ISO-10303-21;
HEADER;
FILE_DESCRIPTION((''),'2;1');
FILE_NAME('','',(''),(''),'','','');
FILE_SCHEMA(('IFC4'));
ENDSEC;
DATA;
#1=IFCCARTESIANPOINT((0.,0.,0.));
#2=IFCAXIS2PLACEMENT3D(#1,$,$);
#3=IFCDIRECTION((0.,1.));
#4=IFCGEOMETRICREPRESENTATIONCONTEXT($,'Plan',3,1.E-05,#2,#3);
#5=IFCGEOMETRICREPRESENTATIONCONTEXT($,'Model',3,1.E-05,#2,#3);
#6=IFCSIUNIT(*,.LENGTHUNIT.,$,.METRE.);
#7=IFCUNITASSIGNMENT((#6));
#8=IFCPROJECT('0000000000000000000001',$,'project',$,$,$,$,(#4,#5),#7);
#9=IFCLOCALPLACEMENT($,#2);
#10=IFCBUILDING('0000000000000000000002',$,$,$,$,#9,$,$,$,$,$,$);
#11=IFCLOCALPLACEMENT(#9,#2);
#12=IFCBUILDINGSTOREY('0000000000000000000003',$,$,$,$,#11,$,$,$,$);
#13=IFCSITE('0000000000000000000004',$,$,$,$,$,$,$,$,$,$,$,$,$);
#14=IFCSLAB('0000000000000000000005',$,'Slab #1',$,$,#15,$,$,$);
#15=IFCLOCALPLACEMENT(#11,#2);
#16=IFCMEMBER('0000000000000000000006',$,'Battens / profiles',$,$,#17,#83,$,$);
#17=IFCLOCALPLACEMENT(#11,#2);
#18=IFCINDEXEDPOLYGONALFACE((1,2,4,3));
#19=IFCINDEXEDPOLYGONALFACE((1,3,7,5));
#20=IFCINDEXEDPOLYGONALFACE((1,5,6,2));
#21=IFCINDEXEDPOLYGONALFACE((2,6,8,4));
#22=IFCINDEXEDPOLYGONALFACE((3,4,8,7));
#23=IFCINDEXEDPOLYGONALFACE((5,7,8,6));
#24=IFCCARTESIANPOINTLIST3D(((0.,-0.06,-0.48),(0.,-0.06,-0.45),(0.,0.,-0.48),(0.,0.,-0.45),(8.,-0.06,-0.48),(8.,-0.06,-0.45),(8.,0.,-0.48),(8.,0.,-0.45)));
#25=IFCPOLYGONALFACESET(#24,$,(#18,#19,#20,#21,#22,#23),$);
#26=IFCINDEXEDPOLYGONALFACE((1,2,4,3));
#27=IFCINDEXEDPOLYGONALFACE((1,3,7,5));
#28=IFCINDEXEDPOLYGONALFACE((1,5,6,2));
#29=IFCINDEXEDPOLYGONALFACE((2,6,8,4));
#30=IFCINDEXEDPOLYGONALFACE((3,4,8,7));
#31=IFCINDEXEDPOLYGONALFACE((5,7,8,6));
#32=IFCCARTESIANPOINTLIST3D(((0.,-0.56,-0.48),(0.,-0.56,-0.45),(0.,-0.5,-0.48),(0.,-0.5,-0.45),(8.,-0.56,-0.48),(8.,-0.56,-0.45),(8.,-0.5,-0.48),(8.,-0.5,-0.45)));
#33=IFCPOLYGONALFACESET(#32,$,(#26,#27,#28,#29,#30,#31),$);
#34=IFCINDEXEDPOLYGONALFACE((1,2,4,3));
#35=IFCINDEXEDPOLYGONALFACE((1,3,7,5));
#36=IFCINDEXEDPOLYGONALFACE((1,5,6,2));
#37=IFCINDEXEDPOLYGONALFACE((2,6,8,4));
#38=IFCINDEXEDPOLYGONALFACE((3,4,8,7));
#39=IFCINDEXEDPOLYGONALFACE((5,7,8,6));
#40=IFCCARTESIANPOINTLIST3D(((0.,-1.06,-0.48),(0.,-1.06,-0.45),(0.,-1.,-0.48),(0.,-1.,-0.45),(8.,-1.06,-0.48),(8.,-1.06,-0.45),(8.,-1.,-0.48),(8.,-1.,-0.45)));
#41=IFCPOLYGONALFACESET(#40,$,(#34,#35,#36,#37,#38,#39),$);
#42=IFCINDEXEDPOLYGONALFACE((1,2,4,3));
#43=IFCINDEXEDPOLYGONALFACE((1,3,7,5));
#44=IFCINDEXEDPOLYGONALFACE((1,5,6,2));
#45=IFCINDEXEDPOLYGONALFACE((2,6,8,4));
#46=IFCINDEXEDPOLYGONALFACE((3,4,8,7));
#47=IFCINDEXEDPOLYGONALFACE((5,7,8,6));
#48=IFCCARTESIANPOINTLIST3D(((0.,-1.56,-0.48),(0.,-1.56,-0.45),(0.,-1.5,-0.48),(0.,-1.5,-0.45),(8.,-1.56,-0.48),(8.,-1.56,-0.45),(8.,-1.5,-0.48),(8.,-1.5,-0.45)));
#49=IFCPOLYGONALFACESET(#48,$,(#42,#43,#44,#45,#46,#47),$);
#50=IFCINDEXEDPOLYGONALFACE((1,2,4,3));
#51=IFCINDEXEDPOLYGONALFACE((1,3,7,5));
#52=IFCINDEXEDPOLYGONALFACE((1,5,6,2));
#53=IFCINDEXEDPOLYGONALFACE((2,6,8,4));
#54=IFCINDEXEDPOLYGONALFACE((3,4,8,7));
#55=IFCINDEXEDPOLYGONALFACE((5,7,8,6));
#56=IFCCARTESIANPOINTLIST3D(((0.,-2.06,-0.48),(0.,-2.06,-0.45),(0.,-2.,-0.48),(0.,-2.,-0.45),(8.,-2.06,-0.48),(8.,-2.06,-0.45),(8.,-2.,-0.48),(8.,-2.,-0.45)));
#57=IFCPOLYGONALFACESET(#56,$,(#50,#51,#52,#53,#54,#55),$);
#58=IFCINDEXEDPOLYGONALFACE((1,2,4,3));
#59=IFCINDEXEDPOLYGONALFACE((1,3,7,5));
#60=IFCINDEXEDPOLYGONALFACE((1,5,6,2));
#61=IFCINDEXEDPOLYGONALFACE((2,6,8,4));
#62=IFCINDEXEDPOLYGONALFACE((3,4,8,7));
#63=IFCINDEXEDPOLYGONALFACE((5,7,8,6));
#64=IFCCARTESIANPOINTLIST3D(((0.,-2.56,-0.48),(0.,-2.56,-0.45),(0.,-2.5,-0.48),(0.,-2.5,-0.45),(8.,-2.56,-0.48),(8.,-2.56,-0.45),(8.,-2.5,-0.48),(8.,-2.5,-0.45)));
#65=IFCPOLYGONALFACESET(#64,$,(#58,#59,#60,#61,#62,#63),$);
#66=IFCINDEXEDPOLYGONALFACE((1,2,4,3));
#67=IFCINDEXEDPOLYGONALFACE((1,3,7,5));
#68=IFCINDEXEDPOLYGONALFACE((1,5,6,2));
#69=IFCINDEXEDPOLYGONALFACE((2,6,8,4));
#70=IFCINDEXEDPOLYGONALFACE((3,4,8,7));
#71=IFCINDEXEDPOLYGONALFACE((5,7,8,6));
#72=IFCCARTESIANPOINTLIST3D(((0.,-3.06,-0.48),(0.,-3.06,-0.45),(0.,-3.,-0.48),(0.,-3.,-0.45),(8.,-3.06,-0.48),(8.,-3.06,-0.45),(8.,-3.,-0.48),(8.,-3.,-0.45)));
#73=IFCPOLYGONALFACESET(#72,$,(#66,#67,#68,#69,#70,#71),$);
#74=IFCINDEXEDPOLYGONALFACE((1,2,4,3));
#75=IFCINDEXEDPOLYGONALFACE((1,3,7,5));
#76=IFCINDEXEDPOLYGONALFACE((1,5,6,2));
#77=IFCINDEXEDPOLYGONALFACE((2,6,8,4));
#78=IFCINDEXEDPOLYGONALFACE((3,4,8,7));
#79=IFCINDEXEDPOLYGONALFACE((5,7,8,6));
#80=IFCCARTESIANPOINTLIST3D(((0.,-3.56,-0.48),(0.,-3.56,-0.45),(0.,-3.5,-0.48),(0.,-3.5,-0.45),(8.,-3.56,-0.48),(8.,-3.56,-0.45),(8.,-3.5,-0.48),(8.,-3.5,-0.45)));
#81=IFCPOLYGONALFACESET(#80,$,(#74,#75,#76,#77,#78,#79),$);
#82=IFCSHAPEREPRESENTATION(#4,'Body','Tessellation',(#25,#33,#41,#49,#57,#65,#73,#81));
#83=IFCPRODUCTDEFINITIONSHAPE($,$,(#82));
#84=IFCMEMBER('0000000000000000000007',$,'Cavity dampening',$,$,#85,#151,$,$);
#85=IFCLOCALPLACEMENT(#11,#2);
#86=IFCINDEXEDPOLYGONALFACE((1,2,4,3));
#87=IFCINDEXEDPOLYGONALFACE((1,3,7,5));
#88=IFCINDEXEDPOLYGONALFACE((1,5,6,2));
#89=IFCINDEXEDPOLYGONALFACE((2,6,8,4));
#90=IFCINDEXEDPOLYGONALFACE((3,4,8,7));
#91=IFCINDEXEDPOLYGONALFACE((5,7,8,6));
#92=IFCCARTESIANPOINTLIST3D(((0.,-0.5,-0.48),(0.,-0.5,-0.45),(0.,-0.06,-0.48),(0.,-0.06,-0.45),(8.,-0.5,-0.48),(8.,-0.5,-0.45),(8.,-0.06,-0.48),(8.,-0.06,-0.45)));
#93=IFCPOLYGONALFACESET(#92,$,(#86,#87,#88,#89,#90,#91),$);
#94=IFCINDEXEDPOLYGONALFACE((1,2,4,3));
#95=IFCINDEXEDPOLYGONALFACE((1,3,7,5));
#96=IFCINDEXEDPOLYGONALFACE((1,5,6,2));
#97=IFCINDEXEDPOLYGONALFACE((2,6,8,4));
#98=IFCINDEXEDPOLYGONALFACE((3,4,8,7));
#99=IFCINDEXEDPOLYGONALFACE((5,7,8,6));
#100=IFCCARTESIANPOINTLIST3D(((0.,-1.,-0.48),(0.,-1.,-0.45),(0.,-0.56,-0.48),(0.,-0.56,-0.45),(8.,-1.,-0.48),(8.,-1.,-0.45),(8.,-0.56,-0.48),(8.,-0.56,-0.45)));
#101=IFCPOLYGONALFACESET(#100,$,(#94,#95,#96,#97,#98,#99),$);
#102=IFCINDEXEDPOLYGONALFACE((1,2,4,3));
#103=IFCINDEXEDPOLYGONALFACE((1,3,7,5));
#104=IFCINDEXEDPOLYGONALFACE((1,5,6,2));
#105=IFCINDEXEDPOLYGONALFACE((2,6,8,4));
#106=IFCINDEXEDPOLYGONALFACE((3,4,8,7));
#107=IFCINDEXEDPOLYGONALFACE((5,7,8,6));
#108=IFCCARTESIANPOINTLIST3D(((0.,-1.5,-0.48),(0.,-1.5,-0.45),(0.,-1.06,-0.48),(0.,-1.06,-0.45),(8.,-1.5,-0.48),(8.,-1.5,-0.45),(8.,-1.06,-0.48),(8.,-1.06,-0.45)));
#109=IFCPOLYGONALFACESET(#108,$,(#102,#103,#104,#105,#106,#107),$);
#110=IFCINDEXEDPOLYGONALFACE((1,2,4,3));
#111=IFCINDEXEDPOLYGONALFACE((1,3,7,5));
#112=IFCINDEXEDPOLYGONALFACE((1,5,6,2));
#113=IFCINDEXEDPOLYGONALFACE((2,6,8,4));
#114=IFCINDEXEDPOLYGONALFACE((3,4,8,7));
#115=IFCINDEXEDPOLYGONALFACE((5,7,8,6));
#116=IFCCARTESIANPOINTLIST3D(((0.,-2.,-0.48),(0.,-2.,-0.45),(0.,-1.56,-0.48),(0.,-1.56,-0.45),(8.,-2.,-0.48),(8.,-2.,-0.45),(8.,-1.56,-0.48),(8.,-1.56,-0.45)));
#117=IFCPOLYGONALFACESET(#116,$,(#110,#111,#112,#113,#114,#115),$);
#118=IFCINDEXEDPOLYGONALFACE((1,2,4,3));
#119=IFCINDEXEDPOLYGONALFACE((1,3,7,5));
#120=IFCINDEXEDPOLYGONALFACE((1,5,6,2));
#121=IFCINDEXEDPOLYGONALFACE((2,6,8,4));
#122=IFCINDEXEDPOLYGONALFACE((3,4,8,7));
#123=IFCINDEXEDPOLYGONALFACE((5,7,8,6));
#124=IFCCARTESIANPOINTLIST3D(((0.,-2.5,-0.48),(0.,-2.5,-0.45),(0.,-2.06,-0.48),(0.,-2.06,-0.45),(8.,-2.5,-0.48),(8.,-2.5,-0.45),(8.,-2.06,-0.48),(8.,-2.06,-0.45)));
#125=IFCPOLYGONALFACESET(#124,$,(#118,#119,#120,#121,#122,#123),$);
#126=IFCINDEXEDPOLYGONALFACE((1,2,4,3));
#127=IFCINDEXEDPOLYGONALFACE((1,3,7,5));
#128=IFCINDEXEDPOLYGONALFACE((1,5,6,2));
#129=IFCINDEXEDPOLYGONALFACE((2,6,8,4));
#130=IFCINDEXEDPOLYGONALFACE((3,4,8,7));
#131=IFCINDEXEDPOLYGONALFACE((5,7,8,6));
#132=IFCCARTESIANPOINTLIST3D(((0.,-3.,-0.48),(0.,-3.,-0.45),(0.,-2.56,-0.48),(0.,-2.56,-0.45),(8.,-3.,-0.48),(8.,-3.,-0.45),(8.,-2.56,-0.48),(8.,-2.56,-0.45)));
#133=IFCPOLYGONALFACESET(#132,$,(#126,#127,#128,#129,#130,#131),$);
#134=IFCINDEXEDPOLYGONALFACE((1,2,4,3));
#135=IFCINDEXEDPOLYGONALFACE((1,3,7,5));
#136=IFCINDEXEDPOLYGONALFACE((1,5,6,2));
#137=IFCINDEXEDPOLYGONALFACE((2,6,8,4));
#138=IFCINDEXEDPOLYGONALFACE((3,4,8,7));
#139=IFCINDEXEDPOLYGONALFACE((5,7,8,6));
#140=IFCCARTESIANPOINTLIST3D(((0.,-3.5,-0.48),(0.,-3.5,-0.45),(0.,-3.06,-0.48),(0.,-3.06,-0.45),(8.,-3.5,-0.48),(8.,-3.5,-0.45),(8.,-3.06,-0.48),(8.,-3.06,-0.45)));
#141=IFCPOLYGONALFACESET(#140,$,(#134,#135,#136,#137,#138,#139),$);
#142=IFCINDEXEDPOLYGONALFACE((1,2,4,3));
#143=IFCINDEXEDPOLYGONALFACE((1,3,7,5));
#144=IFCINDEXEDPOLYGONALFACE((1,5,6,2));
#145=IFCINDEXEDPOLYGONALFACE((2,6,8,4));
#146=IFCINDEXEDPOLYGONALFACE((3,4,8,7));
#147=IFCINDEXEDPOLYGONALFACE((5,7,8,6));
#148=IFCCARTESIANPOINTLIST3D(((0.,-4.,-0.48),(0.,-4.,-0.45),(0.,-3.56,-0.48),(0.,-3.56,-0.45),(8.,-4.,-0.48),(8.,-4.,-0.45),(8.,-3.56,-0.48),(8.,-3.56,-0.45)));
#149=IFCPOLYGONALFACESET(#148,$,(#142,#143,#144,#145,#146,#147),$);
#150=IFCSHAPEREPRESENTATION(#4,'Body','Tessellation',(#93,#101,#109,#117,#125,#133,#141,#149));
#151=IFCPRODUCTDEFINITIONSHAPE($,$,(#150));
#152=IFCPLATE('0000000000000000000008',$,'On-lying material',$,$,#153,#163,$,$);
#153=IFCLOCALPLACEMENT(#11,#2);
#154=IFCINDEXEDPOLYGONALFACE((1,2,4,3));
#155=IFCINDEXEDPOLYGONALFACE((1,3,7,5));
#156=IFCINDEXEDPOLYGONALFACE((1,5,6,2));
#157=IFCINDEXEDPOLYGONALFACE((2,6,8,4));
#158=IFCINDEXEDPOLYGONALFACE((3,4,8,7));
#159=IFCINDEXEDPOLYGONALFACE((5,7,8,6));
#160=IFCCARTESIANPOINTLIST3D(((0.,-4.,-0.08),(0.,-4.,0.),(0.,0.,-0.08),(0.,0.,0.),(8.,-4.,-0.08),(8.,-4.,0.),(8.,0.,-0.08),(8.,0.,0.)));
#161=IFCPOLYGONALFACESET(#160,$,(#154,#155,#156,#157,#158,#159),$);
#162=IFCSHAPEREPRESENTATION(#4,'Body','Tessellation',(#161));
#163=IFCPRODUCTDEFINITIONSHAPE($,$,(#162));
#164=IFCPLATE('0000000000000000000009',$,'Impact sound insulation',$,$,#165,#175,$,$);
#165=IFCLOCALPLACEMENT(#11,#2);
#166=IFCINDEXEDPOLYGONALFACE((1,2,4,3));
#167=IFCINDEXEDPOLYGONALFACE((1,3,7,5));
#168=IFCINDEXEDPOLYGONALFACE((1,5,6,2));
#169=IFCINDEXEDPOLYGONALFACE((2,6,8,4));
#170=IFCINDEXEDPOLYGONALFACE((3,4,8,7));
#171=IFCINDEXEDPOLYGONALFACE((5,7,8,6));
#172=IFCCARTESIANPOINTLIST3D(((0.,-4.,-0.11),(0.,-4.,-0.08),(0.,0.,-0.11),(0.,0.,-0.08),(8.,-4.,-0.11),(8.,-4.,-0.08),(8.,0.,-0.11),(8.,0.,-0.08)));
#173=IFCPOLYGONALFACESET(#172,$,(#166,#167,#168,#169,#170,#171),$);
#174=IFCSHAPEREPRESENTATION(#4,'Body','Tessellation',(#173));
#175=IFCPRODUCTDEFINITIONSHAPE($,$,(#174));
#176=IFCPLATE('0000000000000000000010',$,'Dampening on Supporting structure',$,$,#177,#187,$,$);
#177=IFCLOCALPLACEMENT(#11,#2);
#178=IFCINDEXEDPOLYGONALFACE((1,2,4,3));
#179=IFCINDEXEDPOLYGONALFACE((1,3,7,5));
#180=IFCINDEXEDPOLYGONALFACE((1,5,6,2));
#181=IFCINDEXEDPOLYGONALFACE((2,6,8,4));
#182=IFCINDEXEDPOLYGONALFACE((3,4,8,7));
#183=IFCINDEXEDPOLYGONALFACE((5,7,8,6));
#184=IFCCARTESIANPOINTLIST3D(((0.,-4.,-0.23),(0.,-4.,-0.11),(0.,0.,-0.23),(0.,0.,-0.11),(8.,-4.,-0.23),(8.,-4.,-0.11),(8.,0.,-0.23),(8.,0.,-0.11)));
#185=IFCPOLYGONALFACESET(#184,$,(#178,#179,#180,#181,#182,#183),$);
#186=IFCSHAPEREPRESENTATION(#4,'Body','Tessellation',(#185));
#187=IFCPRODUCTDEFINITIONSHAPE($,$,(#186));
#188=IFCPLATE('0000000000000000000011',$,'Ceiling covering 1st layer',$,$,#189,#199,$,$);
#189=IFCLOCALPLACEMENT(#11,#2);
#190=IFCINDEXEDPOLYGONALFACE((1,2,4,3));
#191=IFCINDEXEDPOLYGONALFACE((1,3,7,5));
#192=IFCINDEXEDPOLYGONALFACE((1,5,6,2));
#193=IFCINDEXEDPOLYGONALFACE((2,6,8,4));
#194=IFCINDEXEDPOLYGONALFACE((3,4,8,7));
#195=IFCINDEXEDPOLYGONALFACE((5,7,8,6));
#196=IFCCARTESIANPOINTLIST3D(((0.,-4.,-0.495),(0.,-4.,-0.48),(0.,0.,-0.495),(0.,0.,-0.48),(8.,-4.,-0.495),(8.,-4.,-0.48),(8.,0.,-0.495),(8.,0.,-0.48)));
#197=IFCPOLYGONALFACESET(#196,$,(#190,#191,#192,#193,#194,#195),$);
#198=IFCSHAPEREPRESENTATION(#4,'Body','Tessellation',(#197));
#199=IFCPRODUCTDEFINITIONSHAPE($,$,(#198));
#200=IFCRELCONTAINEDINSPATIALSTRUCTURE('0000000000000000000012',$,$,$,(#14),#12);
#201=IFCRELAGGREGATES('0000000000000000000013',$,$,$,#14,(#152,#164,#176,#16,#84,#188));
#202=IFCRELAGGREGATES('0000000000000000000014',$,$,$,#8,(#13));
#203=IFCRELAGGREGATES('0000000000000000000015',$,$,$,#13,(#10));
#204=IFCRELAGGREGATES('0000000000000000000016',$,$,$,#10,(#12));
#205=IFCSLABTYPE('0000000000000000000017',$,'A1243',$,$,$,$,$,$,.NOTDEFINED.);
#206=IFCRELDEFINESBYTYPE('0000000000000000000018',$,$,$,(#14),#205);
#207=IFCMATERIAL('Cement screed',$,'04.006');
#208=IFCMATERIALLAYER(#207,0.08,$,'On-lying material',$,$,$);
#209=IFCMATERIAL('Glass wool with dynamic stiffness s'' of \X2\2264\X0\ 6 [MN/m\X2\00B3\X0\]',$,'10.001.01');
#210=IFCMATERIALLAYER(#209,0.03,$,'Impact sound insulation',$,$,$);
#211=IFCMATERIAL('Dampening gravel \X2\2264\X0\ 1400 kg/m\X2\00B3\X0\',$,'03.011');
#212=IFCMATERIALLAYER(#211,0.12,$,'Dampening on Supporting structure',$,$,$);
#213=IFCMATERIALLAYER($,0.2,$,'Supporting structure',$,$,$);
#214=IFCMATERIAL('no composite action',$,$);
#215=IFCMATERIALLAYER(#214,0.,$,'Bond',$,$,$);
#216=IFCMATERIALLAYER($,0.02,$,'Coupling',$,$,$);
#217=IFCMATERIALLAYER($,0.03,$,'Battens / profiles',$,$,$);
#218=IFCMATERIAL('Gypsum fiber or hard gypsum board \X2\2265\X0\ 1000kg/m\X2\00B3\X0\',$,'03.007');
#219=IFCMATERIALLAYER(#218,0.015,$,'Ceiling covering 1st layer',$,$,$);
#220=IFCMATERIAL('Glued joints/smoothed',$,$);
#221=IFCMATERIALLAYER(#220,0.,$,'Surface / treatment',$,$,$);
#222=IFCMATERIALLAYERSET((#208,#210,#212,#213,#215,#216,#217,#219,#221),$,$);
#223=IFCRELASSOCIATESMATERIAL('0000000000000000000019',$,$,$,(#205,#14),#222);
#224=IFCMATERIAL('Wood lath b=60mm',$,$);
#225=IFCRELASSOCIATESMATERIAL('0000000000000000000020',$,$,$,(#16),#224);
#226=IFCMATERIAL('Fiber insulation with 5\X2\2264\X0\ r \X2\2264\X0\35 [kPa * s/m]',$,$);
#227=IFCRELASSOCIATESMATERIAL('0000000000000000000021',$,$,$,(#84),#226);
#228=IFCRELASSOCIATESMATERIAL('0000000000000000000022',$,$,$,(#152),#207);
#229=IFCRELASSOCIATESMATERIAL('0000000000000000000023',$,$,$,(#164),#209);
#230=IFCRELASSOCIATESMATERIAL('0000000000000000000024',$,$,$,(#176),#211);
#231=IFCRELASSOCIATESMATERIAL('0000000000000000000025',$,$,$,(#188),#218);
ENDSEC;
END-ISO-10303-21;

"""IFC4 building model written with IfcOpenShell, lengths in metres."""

from ifc_helpers import new_model, si_unit, direction, frame, frame_2d, origin, origin_with_axes, place, context, project, spatial, rectangle, extrude, material, layer, layer_set, type_object, element, aggregate, save


model = new_model("IFC4")

# Units and contexts
plan_context = context("Plan", 3, precision=1e-05, world=origin(), true_north=direction((0.0, 1.0)))
model_context = context("Model", 3, precision=1e-05, world=origin(), true_north=direction((0.0, 1.0)))
ifc_project = project(units=[si_unit("LENGTHUNIT", "METRE")], contexts=[plan_context, model_context])

# Site, building, storey
site = spatial("IfcSite", under=ifc_project)
building_placement = place(None, origin())
building = spatial("IfcBuilding", under=site, at=building_placement)
storey_placement = place(building_placement, origin())
storey = spatial("IfcBuildingStorey", under=building, at=storey_placement)

# Slab, members, plates
ifc_material_1 = material(Name="Cement screed", Category="04.006")
ifc_layer_1 = layer(ifc_material_1, 0.08, Name="On-lying material")
ifc_material_2 = material(Name="Glass wool with dynamic stiffness s' of ≤ 6 [MN/m³]", Category="10.001.01")
ifc_layer_2 = layer(ifc_material_2, 0.03, Name="Impact sound insulation")
ifc_material_3 = material(Name="Dampening gravel ≤ 1400 kg/m³", Category="03.011")
ifc_layer_3 = layer(ifc_material_3, 0.12, Name="Dampening on Supporting structure")
ifc_layer_4 = layer(None, 0.2, Name="Supporting structure")
ifc_material_4 = material(Name="no composite action")
ifc_layer_5 = layer(ifc_material_4, 0.0, Name="Bond")
ifc_layer_6 = layer(None, 0.02, Name="Coupling")
ifc_layer_7 = layer(None, 0.03, Name="Battens / profiles")
ifc_material_5 = material(Name="Gypsum fiber or hard gypsum board ≥ 1000kg/m³", Category="03.007")
ifc_layer_8 = layer(ifc_material_5, 0.015, Name="Ceiling covering 1st layer")
ifc_material_6 = material(Name="Glued joints/smoothed")
ifc_layer_9 = layer(ifc_material_6, 0.0, Name="Surface / treatment")
ifc_layer_set = layer_set([ifc_layer_1, ifc_layer_2, ifc_layer_3, ifc_layer_4, ifc_layer_5, ifc_layer_6, ifc_layer_7, ifc_layer_8, ifc_layer_9])
slab_type = type_object("IfcSlabType", Name="A1243", PredefinedType="NOTDEFINED", material=ifc_layer_set)
slab_placement = place(None, frame((0.0, 0.0, 0.0), z_axis=(0.0, 0.0, -1.0), x_axis=(1.0, 0.0, 0.0)))
slab = element("IfcSlab", 1, at=slab_placement, inside=storey, type_object=slab_type, material=ifc_layer_set, Name="Slab #1")
ifc_material_7 = material(Name="Wood lath b=60mm")
member_1_placement = place(slab_placement, origin())
member_1 = element("IfcMember", 2, at=member_1_placement, material=ifc_material_7, Name="Battens / profiles", context=plan_context, shape_type="SweptSolid", body=[
    extrude(rectangle(XDim=0.06, YDim=0.03, at=frame_2d((0.03, 0.015), x_axis=(1.0, 0.0))), frame((0.0, 0.0, 0.45), z_axis=(1.0, 0.0, 0.0), x_axis=(0.0, 1.0, 0.0)), (0.0, 0.0, 1.0), 8.0),
    extrude(rectangle(XDim=0.06, YDim=0.03, at=frame_2d((0.03, 0.015), x_axis=(1.0, 0.0))), frame((0.0, 0.5, 0.45), z_axis=(1.0, 0.0, 0.0), x_axis=(0.0, 1.0, 0.0)), (0.0, 0.0, 1.0), 8.0),
    extrude(rectangle(XDim=0.06, YDim=0.03, at=frame_2d((0.03, 0.015), x_axis=(1.0, 0.0))), frame((0.0, 1.0, 0.45), z_axis=(1.0, 0.0, 0.0), x_axis=(0.0, 1.0, 0.0)), (0.0, 0.0, 1.0), 8.0),
    extrude(rectangle(XDim=0.06, YDim=0.03, at=frame_2d((0.03, 0.015), x_axis=(1.0, 0.0))), frame((0.0, 1.5, 0.45), z_axis=(1.0, 0.0, 0.0), x_axis=(0.0, 1.0, 0.0)), (0.0, 0.0, 1.0), 8.0),
    extrude(rectangle(XDim=0.06, YDim=0.03, at=frame_2d((0.03, 0.015), x_axis=(1.0, 0.0))), frame((0.0, 2.0, 0.45), z_axis=(1.0, 0.0, 0.0), x_axis=(0.0, 1.0, 0.0)), (0.0, 0.0, 1.0), 8.0),
    extrude(rectangle(XDim=0.06, YDim=0.03, at=frame_2d((0.03, 0.015), x_axis=(1.0, 0.0))), frame((0.0, 2.5, 0.45), z_axis=(1.0, 0.0, 0.0), x_axis=(0.0, 1.0, 0.0)), (0.0, 0.0, 1.0), 8.0),
    extrude(rectangle(XDim=0.06, YDim=0.03, at=frame_2d((0.03, 0.015), x_axis=(1.0, 0.0))), frame((0.0, 3.0, 0.45), z_axis=(1.0, 0.0, 0.0), x_axis=(0.0, 1.0, 0.0)), (0.0, 0.0, 1.0), 8.0),
    extrude(rectangle(XDim=0.06, YDim=0.03, at=frame_2d((0.03, 0.015), x_axis=(1.0, 0.0))), frame((0.0, 3.5, 0.45), z_axis=(1.0, 0.0, 0.0), x_axis=(0.0, 1.0, 0.0)), (0.0, 0.0, 1.0), 8.0),
])
ifc_material_8 = material(Name="Fiber insulation with 5≤ r ≤35 [kPa * s/m]")
member_2_placement = place(slab_placement, origin())
member_2 = element("IfcMember", 3, at=member_2_placement, material=ifc_material_8, Name="Cavity dampening", context=plan_context, shape_type="SweptSolid", body=[
    extrude(rectangle(XDim=0.44, YDim=0.03, at=frame_2d((0.22, 0.015), x_axis=(1.0, 0.0))), frame((0.0, 0.06, 0.45), z_axis=(1.0, 0.0, 0.0), x_axis=(0.0, 1.0, 0.0)), (0.0, 0.0, 1.0), 8.0),
    extrude(rectangle(XDim=0.44, YDim=0.03, at=frame_2d((0.22, 0.015), x_axis=(1.0, 0.0))), frame((0.0, 0.56, 0.45), z_axis=(1.0, 0.0, 0.0), x_axis=(0.0, 1.0, 0.0)), (0.0, 0.0, 1.0), 8.0),
    extrude(rectangle(XDim=0.44, YDim=0.03, at=frame_2d((0.22, 0.015), x_axis=(1.0, 0.0))), frame((0.0, 1.06, 0.45), z_axis=(1.0, 0.0, 0.0), x_axis=(0.0, 1.0, 0.0)), (0.0, 0.0, 1.0), 8.0),
    extrude(rectangle(XDim=0.44, YDim=0.03, at=frame_2d((0.22, 0.015), x_axis=(1.0, 0.0))), frame((0.0, 1.56, 0.45), z_axis=(1.0, 0.0, 0.0), x_axis=(0.0, 1.0, 0.0)), (0.0, 0.0, 1.0), 8.0),
    extrude(rectangle(XDim=0.44, YDim=0.03, at=frame_2d((0.22, 0.015), x_axis=(1.0, 0.0))), frame((0.0, 2.06, 0.45), z_axis=(1.0, 0.0, 0.0), x_axis=(0.0, 1.0, 0.0)), (0.0, 0.0, 1.0), 8.0),
    extrude(rectangle(XDim=0.44, YDim=0.03, at=frame_2d((0.22, 0.015), x_axis=(1.0, 0.0))), frame((0.0, 2.56, 0.45), z_axis=(1.0, 0.0, 0.0), x_axis=(0.0, 1.0, 0.0)), (0.0, 0.0, 1.0), 8.0),
    extrude(rectangle(XDim=0.44, YDim=0.03, at=frame_2d((0.22, 0.015), x_axis=(1.0, 0.0))), frame((0.0, 3.06, 0.45), z_axis=(1.0, 0.0, 0.0), x_axis=(0.0, 1.0, 0.0)), (0.0, 0.0, 1.0), 8.0),
    extrude(rectangle(XDim=0.44, YDim=0.03, at=frame_2d((0.22, 0.015), x_axis=(1.0, 0.0))), frame((0.0, 3.56, 0.45), z_axis=(1.0, 0.0, 0.0), x_axis=(0.0, 1.0, 0.0)), (0.0, 0.0, 1.0), 8.0),
])
plate_1_placement = place(slab_placement, origin())
plate_1 = element("IfcPlate", 4, at=plate_1_placement, material=ifc_material_1, Name="On-lying material", context=plan_context, shape_type="SweptSolid", body=[
    extrude(rectangle(XDim=8.0, YDim=4.0, at=frame_2d((4.0, 2.0), x_axis=(1.0, 0.0))), origin_with_axes(), (0.0, 0.0, 1.0), 0.08),
])
plate_2_placement = place(slab_placement, origin())
plate_2 = element("IfcPlate", 5, at=plate_2_placement, material=ifc_material_2, Name="Impact sound insulation", context=plan_context, shape_type="SweptSolid", body=[
    extrude(rectangle(XDim=8.0, YDim=4.0, at=frame_2d((4.0, 2.0), x_axis=(1.0, 0.0))), frame((0.0, 0.0, 0.08), z_axis=(0.0, 0.0, 1.0), x_axis=(1.0, 0.0, 0.0)), (0.0, 0.0, 1.0), 0.03),
])
plate_3_placement = place(slab_placement, origin())
plate_3 = element("IfcPlate", 6, at=plate_3_placement, material=ifc_material_3, Name="Dampening on Supporting structure", context=plan_context, shape_type="SweptSolid", body=[
    extrude(rectangle(XDim=8.0, YDim=4.0, at=frame_2d((4.0, 2.0), x_axis=(1.0, 0.0))), frame((0.0, 0.0, 0.11), z_axis=(0.0, 0.0, 1.0), x_axis=(1.0, 0.0, 0.0)), (0.0, 0.0, 1.0), 0.12),
])
plate_4_placement = place(slab_placement, origin())
plate_4 = element("IfcPlate", 7, at=plate_4_placement, material=ifc_material_5, Name="Ceiling covering 1st layer", context=plan_context, shape_type="SweptSolid", body=[
    extrude(rectangle(XDim=8.0, YDim=4.0, at=frame_2d((4.0, 2.0), x_axis=(1.0, 0.0))), frame((0.0, 0.0, 0.48), z_axis=(0.0, 0.0, 1.0), x_axis=(1.0, 0.0, 0.0)), (0.0, 0.0, 1.0), 0.015),
])
aggregate(slab, [plate_1, plate_2, plate_3, member_1, member_2, plate_4])

save(model, "model.ifc")
